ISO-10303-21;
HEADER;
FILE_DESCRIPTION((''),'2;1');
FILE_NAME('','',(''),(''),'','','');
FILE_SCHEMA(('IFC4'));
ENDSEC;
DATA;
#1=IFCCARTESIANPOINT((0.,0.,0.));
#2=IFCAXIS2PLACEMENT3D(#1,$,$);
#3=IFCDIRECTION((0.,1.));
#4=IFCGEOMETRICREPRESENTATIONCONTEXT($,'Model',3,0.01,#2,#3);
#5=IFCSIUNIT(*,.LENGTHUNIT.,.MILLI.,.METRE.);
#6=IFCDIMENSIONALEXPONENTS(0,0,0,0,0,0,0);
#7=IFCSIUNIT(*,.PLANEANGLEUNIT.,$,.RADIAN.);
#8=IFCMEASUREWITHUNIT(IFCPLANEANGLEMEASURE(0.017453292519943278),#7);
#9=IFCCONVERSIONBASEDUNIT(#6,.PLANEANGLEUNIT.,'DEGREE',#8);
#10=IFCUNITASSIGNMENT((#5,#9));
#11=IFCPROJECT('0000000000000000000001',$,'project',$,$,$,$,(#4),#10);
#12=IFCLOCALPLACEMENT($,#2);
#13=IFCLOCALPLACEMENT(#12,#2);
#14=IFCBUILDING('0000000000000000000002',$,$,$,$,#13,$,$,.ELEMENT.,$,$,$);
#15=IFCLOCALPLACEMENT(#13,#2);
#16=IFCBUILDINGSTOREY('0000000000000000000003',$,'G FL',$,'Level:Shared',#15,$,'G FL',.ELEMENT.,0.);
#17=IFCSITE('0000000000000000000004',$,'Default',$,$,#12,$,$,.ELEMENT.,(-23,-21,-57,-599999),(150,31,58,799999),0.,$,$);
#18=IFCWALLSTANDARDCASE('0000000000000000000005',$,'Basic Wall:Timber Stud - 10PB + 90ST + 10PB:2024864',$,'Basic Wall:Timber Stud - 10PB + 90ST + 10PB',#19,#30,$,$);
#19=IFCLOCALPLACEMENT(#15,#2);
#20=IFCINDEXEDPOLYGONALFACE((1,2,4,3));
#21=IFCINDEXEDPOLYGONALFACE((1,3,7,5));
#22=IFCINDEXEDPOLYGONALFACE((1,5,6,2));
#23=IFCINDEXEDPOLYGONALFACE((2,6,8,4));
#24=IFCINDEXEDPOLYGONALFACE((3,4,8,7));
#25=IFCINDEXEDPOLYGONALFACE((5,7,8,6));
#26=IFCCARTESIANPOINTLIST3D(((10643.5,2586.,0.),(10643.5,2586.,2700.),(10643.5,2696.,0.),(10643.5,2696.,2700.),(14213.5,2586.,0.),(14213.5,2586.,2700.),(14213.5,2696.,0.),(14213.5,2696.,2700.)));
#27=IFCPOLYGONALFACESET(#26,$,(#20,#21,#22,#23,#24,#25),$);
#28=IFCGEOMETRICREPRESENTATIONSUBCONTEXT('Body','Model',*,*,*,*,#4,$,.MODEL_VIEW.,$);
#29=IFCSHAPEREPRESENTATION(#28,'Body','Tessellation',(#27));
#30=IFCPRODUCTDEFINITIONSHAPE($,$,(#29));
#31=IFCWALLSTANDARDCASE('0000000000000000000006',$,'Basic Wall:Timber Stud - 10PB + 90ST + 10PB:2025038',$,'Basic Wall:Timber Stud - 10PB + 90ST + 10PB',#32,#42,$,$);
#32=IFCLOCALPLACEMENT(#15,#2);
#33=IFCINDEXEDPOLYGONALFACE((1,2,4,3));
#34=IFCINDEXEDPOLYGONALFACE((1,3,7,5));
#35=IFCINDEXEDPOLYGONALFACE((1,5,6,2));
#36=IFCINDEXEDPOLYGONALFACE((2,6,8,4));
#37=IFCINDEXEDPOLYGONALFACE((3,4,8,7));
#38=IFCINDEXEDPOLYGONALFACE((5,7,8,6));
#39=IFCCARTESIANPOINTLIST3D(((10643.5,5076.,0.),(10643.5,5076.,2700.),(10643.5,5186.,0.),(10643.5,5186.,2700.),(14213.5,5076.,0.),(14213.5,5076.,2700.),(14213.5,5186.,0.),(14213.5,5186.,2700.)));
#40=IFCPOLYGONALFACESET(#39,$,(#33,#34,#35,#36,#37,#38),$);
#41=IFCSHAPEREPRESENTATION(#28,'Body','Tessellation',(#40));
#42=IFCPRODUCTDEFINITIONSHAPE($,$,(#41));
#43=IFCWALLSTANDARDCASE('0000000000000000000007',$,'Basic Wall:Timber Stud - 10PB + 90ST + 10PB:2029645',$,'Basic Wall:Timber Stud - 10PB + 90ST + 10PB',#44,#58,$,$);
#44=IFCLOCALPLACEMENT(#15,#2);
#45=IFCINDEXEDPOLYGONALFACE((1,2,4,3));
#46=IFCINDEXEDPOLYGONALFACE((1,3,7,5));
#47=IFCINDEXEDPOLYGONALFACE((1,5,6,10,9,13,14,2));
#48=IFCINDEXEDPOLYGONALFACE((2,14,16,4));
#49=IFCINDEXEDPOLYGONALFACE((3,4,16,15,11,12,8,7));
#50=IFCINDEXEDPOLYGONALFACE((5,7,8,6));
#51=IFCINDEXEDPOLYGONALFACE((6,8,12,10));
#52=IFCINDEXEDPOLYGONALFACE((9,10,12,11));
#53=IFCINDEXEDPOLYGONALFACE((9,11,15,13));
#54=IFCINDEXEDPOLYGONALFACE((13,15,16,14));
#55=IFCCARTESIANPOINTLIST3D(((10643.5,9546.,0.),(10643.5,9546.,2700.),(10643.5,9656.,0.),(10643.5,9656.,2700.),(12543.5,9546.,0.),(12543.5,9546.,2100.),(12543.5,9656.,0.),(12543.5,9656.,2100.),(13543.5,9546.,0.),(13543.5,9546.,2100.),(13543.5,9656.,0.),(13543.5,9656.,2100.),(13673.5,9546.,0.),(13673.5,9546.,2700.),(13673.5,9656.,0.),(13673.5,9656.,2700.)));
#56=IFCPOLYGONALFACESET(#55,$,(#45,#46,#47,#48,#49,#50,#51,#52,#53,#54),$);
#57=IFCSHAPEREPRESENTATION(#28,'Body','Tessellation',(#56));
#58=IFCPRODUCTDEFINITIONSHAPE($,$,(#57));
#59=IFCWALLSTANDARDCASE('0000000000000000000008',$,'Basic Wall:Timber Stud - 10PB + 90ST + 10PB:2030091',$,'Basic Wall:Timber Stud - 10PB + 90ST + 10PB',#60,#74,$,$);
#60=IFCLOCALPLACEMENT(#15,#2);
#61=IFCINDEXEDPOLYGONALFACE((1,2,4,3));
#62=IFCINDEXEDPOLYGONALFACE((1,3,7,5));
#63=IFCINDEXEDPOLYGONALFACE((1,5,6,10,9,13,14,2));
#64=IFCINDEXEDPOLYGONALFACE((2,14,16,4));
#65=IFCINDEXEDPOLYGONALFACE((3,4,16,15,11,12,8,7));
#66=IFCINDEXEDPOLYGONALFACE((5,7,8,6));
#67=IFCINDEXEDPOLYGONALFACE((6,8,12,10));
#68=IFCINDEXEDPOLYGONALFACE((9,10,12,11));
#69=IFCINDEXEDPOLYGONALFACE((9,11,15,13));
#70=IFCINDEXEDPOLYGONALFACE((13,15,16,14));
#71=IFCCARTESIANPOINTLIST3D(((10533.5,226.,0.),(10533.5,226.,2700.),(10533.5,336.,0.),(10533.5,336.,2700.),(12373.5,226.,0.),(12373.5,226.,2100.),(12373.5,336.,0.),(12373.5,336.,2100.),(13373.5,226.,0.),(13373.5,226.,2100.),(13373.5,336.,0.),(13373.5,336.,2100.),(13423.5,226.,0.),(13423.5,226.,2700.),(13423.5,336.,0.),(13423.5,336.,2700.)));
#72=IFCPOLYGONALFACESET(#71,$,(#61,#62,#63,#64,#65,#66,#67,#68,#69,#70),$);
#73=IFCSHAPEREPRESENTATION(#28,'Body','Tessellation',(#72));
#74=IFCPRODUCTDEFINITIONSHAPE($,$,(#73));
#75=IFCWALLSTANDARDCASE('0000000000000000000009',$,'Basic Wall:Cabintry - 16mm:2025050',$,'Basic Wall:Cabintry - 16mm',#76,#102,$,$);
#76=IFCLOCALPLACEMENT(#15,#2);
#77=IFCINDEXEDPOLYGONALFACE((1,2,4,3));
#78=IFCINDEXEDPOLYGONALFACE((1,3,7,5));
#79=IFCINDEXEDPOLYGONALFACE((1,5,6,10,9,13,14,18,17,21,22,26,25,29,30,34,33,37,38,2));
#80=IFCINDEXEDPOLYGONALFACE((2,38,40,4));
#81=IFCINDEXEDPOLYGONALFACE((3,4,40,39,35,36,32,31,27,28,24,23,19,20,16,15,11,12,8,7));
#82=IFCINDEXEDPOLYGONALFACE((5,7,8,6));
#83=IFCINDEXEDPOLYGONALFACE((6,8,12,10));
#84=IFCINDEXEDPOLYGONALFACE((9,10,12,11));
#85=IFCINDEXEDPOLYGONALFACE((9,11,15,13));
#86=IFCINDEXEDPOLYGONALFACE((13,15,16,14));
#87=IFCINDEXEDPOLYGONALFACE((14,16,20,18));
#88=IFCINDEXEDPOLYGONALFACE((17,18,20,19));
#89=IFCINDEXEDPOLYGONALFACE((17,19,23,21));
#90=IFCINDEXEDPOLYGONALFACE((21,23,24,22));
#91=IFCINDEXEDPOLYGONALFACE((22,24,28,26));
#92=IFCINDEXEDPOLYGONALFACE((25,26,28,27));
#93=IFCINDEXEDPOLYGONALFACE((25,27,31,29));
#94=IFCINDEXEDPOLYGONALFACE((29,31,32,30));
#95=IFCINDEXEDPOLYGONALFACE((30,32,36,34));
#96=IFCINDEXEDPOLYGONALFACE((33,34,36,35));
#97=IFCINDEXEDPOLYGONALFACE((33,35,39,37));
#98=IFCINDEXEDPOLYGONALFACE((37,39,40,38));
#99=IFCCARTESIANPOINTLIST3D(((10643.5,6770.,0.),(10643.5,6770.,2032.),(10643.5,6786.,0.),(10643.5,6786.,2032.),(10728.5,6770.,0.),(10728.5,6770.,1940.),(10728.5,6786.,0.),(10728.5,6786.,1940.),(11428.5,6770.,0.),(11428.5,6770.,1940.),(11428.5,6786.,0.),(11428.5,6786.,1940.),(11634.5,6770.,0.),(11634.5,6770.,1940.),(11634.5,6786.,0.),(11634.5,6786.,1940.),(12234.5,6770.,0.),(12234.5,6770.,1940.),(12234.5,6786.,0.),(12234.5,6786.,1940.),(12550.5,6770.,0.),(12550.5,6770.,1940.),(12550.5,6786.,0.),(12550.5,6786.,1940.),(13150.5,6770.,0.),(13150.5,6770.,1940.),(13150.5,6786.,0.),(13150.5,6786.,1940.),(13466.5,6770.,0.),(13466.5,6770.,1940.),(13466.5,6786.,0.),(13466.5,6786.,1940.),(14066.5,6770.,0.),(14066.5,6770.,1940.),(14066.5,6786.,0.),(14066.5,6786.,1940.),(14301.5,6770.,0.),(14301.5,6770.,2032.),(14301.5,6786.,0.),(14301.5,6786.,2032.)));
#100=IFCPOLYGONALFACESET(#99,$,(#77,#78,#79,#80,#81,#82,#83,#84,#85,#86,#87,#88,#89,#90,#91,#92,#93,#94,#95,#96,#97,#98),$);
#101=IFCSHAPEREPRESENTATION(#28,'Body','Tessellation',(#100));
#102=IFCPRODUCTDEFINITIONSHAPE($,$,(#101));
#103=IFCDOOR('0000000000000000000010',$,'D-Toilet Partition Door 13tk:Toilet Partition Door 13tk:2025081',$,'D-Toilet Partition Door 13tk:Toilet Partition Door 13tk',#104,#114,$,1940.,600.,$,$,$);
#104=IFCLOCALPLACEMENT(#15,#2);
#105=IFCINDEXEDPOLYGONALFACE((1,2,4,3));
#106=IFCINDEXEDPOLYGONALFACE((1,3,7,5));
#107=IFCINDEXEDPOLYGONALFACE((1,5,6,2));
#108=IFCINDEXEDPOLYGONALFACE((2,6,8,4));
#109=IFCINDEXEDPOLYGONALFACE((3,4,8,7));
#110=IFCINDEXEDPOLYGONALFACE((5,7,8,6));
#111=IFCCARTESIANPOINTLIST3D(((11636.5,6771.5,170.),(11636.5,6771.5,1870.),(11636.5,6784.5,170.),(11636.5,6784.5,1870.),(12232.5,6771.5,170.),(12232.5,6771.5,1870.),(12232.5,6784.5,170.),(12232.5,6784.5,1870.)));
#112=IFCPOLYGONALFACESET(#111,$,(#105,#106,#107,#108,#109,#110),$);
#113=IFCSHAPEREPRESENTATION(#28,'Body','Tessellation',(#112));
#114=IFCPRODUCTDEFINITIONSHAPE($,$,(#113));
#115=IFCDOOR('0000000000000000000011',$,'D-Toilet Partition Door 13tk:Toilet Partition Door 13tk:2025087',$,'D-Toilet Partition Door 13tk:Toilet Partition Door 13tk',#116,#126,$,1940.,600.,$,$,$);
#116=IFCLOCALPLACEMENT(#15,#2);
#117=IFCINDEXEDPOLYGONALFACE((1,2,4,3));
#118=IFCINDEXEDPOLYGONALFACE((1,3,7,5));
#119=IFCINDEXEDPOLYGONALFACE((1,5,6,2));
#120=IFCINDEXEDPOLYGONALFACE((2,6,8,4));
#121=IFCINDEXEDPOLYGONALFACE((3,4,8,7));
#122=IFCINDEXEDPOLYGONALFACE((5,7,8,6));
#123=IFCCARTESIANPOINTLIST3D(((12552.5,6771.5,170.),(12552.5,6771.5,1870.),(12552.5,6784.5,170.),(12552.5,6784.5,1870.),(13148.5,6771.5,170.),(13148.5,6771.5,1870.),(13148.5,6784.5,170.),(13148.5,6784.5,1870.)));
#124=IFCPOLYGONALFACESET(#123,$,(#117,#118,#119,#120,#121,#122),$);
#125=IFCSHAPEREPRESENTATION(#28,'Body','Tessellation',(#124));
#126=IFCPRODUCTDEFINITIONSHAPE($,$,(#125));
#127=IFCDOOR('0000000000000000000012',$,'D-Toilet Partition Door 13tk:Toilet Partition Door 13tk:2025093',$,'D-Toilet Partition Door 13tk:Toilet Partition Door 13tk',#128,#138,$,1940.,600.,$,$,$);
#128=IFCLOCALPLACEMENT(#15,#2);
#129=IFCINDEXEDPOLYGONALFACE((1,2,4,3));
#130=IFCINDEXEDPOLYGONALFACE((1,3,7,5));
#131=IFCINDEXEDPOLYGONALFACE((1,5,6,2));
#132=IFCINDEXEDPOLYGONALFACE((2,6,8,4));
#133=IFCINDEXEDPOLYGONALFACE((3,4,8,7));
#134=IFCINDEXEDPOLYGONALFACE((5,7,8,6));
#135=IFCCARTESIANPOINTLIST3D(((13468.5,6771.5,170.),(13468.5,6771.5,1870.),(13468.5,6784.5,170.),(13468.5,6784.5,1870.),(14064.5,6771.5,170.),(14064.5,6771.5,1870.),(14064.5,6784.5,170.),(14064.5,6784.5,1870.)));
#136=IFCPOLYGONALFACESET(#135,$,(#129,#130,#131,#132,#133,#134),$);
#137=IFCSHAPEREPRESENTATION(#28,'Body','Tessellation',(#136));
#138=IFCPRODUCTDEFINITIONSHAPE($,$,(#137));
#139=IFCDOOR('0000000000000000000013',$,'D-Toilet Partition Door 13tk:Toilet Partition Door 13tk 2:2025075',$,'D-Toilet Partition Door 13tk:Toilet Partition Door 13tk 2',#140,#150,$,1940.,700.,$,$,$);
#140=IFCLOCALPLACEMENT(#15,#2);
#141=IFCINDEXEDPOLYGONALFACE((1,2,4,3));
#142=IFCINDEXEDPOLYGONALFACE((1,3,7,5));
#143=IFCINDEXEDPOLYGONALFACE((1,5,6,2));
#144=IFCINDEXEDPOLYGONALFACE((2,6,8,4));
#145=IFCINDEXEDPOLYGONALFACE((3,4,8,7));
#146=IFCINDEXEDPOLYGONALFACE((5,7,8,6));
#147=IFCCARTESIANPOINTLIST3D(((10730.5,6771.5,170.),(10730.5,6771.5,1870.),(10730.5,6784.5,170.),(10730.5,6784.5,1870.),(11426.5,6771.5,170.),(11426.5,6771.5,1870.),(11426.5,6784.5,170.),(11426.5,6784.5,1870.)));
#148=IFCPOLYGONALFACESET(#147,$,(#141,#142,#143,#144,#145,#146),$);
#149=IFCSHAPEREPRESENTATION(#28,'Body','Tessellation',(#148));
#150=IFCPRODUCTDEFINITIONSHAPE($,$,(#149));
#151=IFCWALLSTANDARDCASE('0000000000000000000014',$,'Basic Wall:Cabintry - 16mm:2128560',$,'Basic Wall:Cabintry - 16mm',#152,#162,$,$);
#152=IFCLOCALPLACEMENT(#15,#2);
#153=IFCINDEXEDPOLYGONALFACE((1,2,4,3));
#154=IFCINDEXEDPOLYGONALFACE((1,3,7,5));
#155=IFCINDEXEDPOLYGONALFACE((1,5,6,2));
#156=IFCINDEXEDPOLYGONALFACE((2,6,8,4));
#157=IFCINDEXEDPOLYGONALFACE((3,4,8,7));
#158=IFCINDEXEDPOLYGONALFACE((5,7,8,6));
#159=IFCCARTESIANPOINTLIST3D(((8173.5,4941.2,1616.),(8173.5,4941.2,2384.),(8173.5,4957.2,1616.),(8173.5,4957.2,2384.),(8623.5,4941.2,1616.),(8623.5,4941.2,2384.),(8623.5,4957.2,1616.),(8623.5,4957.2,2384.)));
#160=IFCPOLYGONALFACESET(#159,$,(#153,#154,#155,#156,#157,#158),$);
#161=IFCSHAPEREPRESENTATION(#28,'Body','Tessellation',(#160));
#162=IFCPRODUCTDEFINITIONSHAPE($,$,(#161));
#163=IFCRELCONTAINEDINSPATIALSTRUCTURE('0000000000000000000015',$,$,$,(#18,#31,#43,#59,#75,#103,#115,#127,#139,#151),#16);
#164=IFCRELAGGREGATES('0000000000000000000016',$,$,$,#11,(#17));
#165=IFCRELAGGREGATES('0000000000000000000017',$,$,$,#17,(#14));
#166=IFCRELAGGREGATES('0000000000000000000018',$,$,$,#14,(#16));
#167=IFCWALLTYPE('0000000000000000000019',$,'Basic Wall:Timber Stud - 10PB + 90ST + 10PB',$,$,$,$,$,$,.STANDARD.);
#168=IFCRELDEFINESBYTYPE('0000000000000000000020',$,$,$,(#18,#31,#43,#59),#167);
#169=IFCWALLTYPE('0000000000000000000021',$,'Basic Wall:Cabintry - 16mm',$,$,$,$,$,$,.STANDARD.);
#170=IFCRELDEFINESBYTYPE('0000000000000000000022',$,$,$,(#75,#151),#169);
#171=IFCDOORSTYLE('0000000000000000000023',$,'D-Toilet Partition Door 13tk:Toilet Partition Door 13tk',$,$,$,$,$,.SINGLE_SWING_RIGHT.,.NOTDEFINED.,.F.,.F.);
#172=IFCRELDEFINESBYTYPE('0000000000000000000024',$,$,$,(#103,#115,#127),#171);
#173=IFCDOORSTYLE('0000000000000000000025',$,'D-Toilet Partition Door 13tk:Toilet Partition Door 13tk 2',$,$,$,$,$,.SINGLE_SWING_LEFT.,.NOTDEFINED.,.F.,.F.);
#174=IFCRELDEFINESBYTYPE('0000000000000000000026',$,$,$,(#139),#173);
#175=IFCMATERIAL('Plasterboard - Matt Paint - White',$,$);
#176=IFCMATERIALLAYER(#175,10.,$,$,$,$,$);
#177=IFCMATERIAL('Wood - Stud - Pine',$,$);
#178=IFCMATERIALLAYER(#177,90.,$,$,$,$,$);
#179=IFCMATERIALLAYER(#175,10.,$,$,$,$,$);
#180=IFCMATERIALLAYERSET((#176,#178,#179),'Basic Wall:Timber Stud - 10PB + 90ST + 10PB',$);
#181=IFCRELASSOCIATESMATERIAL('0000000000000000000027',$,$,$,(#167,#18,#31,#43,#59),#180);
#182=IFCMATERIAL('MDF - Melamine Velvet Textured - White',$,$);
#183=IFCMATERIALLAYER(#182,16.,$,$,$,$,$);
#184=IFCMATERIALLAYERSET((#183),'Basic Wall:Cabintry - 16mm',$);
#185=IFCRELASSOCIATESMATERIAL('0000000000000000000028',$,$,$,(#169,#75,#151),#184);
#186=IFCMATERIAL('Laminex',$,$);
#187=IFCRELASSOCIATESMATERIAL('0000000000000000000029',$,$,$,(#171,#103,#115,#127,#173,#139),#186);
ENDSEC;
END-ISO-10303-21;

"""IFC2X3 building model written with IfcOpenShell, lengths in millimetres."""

from ifc_helpers import new_model, entity, si_unit, converted_unit, direction, frame, frame_2d, origin, origin_2d_with_axis, place, context, subcontext, project, spatial, rectangle, extrude, source, transform, mapped, material, layer, layer_set, layer_usage, type_object, type_shapes, element, fill, save


model = new_model("IFC2X3")

# Units and contexts
model_context = context("Model", 3, precision=0.01, world=origin(), true_north=direction((0.0, 1.0)))
body_context = subcontext(model_context, "Body", "Model", "MODEL_VIEW")
ifc_project = project(units=[si_unit("LENGTHUNIT", "METRE", prefix="MILLI"), converted_unit("PLANEANGLEUNIT", "DEGREE", entity("IfcPlaneAngleMeasure", 0.017453292519943278), si_unit("PLANEANGLEUNIT", "RADIAN"), dimensions=[0, 0, 0, 0, 0, 0, 0])], contexts=[model_context])

# Site, building, storey
site_placement = place(None, origin())
site = spatial("IfcSite", under=ifc_project, at=site_placement, Name="Default", CompositionType="ELEMENT", RefLatitude=(-23, -21, -57, -599999), RefLongitude=(150, 31, 58, 799999), RefElevation=0.0)
building_placement = place(site_placement, origin())
building = spatial("IfcBuilding", under=site, at=building_placement, CompositionType="ELEMENT")
storey_placement = place(building_placement, origin())
storey = spatial("IfcBuildingStorey", under=building, at=storey_placement, Name="G FL", ObjectType="Level:Shared", LongName="G FL", CompositionType="ELEMENT", Elevation=0.0)

# Walls
ifc_material_1 = material(Name="Plasterboard - Matt Paint - White")
ifc_layer_1 = layer(ifc_material_1, 10.0)
ifc_material_2 = material(Name="Wood - Stud - Pine")
ifc_layer_2 = layer(ifc_material_2, 90.0)
ifc_layer_3 = layer(ifc_material_1, 10.0)
ifc_layer_set_1 = layer_set([ifc_layer_1, ifc_layer_2, ifc_layer_3], Name="Basic Wall:Timber Stud - 10PB + 90ST + 10PB")
ifc_layer_usage_1 = layer_usage(ifc_layer_set_1, "AXIS2", "NEGATIVE", 55.0)
wall_type_1 = type_object("IfcWallType", Name="Basic Wall:Timber Stud - 10PB + 90ST + 10PB", PredefinedType="STANDARD", material=ifc_layer_set_1)
wall_1_placement = place(storey_placement, frame((10643.5, 2641.0, 0.0)))
element("IfcWallStandardCase", 1, at=wall_1_placement, inside=storey, type_object=wall_type_1, material=ifc_layer_usage_1, Name="Basic Wall:Timber Stud - 10PB + 90ST + 10PB:2024864", ObjectType="Basic Wall:Timber Stud - 10PB + 90ST + 10PB", context=body_context, shape_type="SweptSolid", body=[
    extrude(rectangle(XDim=3570.0, YDim=110.0, at=frame_2d((1785.0, 0.0), x_axis=(-1.0, 0.0))), origin(), (0.0, 0.0, 1.0), 2700.0),
])
ifc_layer_usage_2 = layer_usage(ifc_layer_set_1, "AXIS2", "POSITIVE", -55.0)
wall_2_placement = place(storey_placement, frame((10643.5, 5131.0, 0.0)))
element("IfcWallStandardCase", 2, at=wall_2_placement, inside=storey, type_object=wall_type_1, material=ifc_layer_usage_2, Name="Basic Wall:Timber Stud - 10PB + 90ST + 10PB:2025038", ObjectType="Basic Wall:Timber Stud - 10PB + 90ST + 10PB", context=body_context, shape_type="SweptSolid", body=[
    extrude(rectangle(XDim=3570.0, YDim=110.0, at=frame_2d((1785.0, 0.0), x_axis=(-1.0, 0.0))), origin(), (0.0, 0.0, 1.0), 2700.0),
])

# Walls, openings
ifc_layer_usage_3 = layer_usage(ifc_layer_set_1, "AXIS2", "NEGATIVE", 55.0)
wall_3_placement = place(storey_placement, frame((10643.5, 9601.0, 0.0)))
wall_3 = element("IfcWallStandardCase", 3, at=wall_3_placement, inside=storey, type_object=wall_type_1, material=ifc_layer_usage_3, Name="Basic Wall:Timber Stud - 10PB + 90ST + 10PB:2029645", ObjectType="Basic Wall:Timber Stud - 10PB + 90ST + 10PB", context=body_context, shape_type="SweptSolid", body=[
    extrude(rectangle(XDim=3030.0, YDim=110.0, at=frame_2d((1515.0, 0.0), x_axis=(-1.0, 0.0))), origin(), (0.0, 0.0, 1.0), 2700.0),
])
opening_1_placement = place(wall_3_placement, frame((1900.0, -55.0, 0.0)))
element("IfcOpeningElement", 4, at=opening_1_placement, cuts=wall_3, ObjectType="Opening", context=body_context, shape_type="SweptSolid", body=[
    extrude(rectangle(XDim=2100.0, YDim=1000.0, at=frame_2d((1050.0, 500.0), x_axis=(1.0, 0.0))), frame((0.0, 0.0, 0.0), z_axis=(0.0, 1.0, 0.0), x_axis=(0.0, 0.0, 1.0)), (0.0, 0.0, 1.0), 110.0),
])
ifc_layer_usage_4 = layer_usage(ifc_layer_set_1, "AXIS2", "POSITIVE", -55.0)
wall_4_placement = place(storey_placement, frame((10533.5, 281.0, 0.0)))
wall_4 = element("IfcWallStandardCase", 5, at=wall_4_placement, inside=storey, type_object=wall_type_1, material=ifc_layer_usage_4, Name="Basic Wall:Timber Stud - 10PB + 90ST + 10PB:2030091", ObjectType="Basic Wall:Timber Stud - 10PB + 90ST + 10PB", context=body_context, shape_type="SweptSolid", body=[
    extrude(rectangle(XDim=2890.0, YDim=110.0, at=frame_2d((1445.0, 0.0), x_axis=(-1.0, 0.0))), origin(), (0.0, 0.0, 1.0), 2700.0),
])
opening_2_placement = place(wall_4_placement, frame((2840.0, 55.0, 0.0)))
element("IfcOpeningElement", 6, at=opening_2_placement, cuts=wall_4, ObjectType="Opening", context=body_context, shape_type="SweptSolid", body=[
    extrude(rectangle(XDim=2100.0, YDim=1000.0, at=frame_2d((1050.0, 500.0), x_axis=(1.0, 0.0))), frame((0.0, 0.0, 0.0), z_axis=(0.0, -1.0, 0.0), x_axis=(0.0, 0.0, 1.0)), (0.0, 0.0, 1.0), 110.0),
])

# Wall, openings, doors
ifc_material_3 = material(Name="MDF - Melamine Velvet Textured - White")
ifc_layer_4 = layer(ifc_material_3, 16.0)
ifc_layer_set_2 = layer_set([ifc_layer_4], Name="Basic Wall:Cabintry - 16mm")
ifc_layer_usage_5 = layer_usage(ifc_layer_set_2, "AXIS2", "NEGATIVE", 8.0)
wall_type_2 = type_object("IfcWallType", Name="Basic Wall:Cabintry - 16mm", PredefinedType="STANDARD", material=ifc_layer_set_2)
wall_5_placement = place(storey_placement, frame((10643.5, 6778.0, 0.0)))
wall_5 = element("IfcWallStandardCase", 7, at=wall_5_placement, inside=storey, type_object=wall_type_2, material=ifc_layer_usage_5, Name="Basic Wall:Cabintry - 16mm:2025050", ObjectType="Basic Wall:Cabintry - 16mm", context=body_context, shape_type="SweptSolid", body=[
    extrude(rectangle(XDim=3658.0, YDim=16.0, at=frame_2d((1829.0, 0.0), x_axis=(-1.0, 0.0))), origin(), (0.0, 0.0, 1.0), 2032.0),
])
opening_3_placement = place(wall_5_placement, frame((85.0, -8.0, 0.0)))
opening_3 = element("IfcOpeningElement", 8, at=opening_3_placement, cuts=wall_5, ObjectType="Opening", context=body_context, shape_type="SweptSolid", body=[
    extrude(rectangle(XDim=1940.0, YDim=700.0, at=frame_2d((970.0, 350.0), x_axis=(1.0, 0.0))), frame((0.0, 0.0, 0.0), z_axis=(0.0, 1.0, 0.0), x_axis=(0.0, 0.0, 1.0)), (0.0, 0.0, 1.0), 16.0),
])
opening_4_placement = place(wall_5_placement, frame((1591.0, 8.0, 0.0)))
opening_4 = element("IfcOpeningElement", 9, at=opening_4_placement, cuts=wall_5, ObjectType="Opening", context=body_context, shape_type="SweptSolid", body=[
    extrude(rectangle(XDim=1940.0, YDim=600.0, at=frame_2d((970.0, 300.0), x_axis=(1.0, 0.0))), frame((0.0, 0.0, 0.0), z_axis=(0.0, -1.0, 0.0), x_axis=(0.0, 0.0, 1.0)), (0.0, 0.0, 1.0), 16.0),
])
opening_5_placement = place(wall_5_placement, frame((2507.0, 8.0, 0.0)))
opening_5 = element("IfcOpeningElement", 10, at=opening_5_placement, cuts=wall_5, ObjectType="Opening", context=body_context, shape_type="SweptSolid", body=[
    extrude(rectangle(XDim=1940.0, YDim=600.0, at=frame_2d((970.0, 300.0), x_axis=(1.0, 0.0))), frame((0.0, 0.0, 0.0), z_axis=(0.0, -1.0, 0.0), x_axis=(0.0, 0.0, 1.0)), (0.0, 0.0, 1.0), 16.0),
])
opening_6_placement = place(wall_5_placement, frame((3423.0, 8.0, 0.0)))
opening_6 = element("IfcOpeningElement", 11, at=opening_6_placement, cuts=wall_5, ObjectType="Opening", context=body_context, shape_type="SweptSolid", body=[
    extrude(rectangle(XDim=1940.0, YDim=600.0, at=frame_2d((970.0, 300.0), x_axis=(1.0, 0.0))), frame((0.0, 0.0, 0.0), z_axis=(0.0, -1.0, 0.0), x_axis=(0.0, 0.0, 1.0)), (0.0, 0.0, 1.0), 16.0),
])
ifc_material_4 = material(Name="Laminex")
door_style_1 = type_object("IfcDoorStyle", Name="D-Toilet Partition Door 13tk:Toilet Partition Door 13tk", ConstructionType="NOTDEFINED", OperationType="SINGLE_SWING_RIGHT", ParameterTakesPrecedence=False, Sizeable=False, material=ifc_material_4)
shared_shape_1 = source(origin(), body_context, "Body", "SweptSolid", [
    extrude(rectangle(XDim=596.0, YDim=13.0, at=frame_2d((0.0, 0.0), x_axis=(1.0, 0.0))), frame((300.0, 8.0, 170.0)), (0.0, 0.0, 1.0), 1700.0),
])
type_shapes(door_style_1, [shared_shape_1])
door_1_placement = place(opening_4_placement, frame((0.0, 0.0, 0.0), z_axis=(0.0, 0.0, 1.0), x_axis=(-1.0, 0.0, 0.0)))
door_1 = element("IfcDoor", 12, at=door_1_placement, inside=storey, type_object=door_style_1, material=ifc_material_4, Name="D-Toilet Partition Door 13tk:Toilet Partition Door 13tk:2025081", ObjectType="D-Toilet Partition Door 13tk:Toilet Partition Door 13tk", OverallHeight=1940.0, OverallWidth=600.0, context=body_context, shape_type="MappedRepresentation", body=[
    mapped(shared_shape_1, transform((0.0, 0.0, 0.0), scale=1.0)),
])
fill(opening_4, door_1)
door_2_placement = place(opening_5_placement, frame((0.0, 0.0, 0.0), z_axis=(0.0, 0.0, 1.0), x_axis=(-1.0, 0.0, 0.0)))
door_2 = element("IfcDoor", 13, at=door_2_placement, inside=storey, type_object=door_style_1, material=ifc_material_4, Name="D-Toilet Partition Door 13tk:Toilet Partition Door 13tk:2025087", ObjectType="D-Toilet Partition Door 13tk:Toilet Partition Door 13tk", OverallHeight=1940.0, OverallWidth=600.0, context=body_context, shape_type="MappedRepresentation", body=[
    mapped(shared_shape_1, transform((0.0, 0.0, 0.0), scale=1.0)),
])
fill(opening_5, door_2)
door_3_placement = place(opening_6_placement, frame((0.0, 0.0, 0.0), z_axis=(0.0, 0.0, 1.0), x_axis=(-1.0, 0.0, 0.0)))
door_3 = element("IfcDoor", 14, at=door_3_placement, inside=storey, type_object=door_style_1, material=ifc_material_4, Name="D-Toilet Partition Door 13tk:Toilet Partition Door 13tk:2025093", ObjectType="D-Toilet Partition Door 13tk:Toilet Partition Door 13tk", OverallHeight=1940.0, OverallWidth=600.0, context=body_context, shape_type="MappedRepresentation", body=[
    mapped(shared_shape_1, transform((0.0, 0.0, 0.0), scale=1.0)),
])
fill(opening_6, door_3)
door_style_2 = type_object("IfcDoorStyle", Name="D-Toilet Partition Door 13tk:Toilet Partition Door 13tk 2", ConstructionType="NOTDEFINED", OperationType="SINGLE_SWING_LEFT", ParameterTakesPrecedence=False, Sizeable=False, material=ifc_material_4)
shared_shape_2 = source(origin(), body_context, "Body", "SweptSolid", [
    extrude(rectangle(XDim=13.0, YDim=696.0, at=origin_2d_with_axis()), frame((350.0, 8.0, 170.0), z_axis=(0.0, 0.0, 1.0), x_axis=(0.0, 1.0, 0.0)), (0.0, 0.0, 1.0), 1700.0),
])
type_shapes(door_style_2, [shared_shape_2])
door_4_placement = place(opening_3_placement, origin())
door_4 = element("IfcDoor", 15, at=door_4_placement, inside=storey, type_object=door_style_2, material=ifc_material_4, Name="D-Toilet Partition Door 13tk:Toilet Partition Door 13tk 2:2025075", ObjectType="D-Toilet Partition Door 13tk:Toilet Partition Door 13tk 2", OverallHeight=1940.0, OverallWidth=700.0, context=body_context, shape_type="MappedRepresentation", body=[
    mapped(shared_shape_2, transform((0.0, 0.0, 0.0), scale=1.0)),
])
fill(opening_3, door_4)

# Wall
ifc_layer_usage_6 = layer_usage(ifc_layer_set_2, "AXIS2", "NEGATIVE", 8.0)
wall_6_placement = place(storey_placement, frame((8623.5, 4949.2, 1616.0), z_axis=(0.0, 0.0, 1.0), x_axis=(-1.0, 0.0, 0.0)))
element("IfcWallStandardCase", 16, at=wall_6_placement, inside=storey, type_object=wall_type_2, material=ifc_layer_usage_6, Name="Basic Wall:Cabintry - 16mm:2128560", ObjectType="Basic Wall:Cabintry - 16mm", context=body_context, shape_type="SweptSolid", body=[
    extrude(rectangle(XDim=450.0, YDim=16.0, at=frame_2d((225.0, 0.0), x_axis=(-1.0, 0.0))), origin(), (0.0, 0.0, 1.0), 768.0),
])

save(model, "model.ifc")
